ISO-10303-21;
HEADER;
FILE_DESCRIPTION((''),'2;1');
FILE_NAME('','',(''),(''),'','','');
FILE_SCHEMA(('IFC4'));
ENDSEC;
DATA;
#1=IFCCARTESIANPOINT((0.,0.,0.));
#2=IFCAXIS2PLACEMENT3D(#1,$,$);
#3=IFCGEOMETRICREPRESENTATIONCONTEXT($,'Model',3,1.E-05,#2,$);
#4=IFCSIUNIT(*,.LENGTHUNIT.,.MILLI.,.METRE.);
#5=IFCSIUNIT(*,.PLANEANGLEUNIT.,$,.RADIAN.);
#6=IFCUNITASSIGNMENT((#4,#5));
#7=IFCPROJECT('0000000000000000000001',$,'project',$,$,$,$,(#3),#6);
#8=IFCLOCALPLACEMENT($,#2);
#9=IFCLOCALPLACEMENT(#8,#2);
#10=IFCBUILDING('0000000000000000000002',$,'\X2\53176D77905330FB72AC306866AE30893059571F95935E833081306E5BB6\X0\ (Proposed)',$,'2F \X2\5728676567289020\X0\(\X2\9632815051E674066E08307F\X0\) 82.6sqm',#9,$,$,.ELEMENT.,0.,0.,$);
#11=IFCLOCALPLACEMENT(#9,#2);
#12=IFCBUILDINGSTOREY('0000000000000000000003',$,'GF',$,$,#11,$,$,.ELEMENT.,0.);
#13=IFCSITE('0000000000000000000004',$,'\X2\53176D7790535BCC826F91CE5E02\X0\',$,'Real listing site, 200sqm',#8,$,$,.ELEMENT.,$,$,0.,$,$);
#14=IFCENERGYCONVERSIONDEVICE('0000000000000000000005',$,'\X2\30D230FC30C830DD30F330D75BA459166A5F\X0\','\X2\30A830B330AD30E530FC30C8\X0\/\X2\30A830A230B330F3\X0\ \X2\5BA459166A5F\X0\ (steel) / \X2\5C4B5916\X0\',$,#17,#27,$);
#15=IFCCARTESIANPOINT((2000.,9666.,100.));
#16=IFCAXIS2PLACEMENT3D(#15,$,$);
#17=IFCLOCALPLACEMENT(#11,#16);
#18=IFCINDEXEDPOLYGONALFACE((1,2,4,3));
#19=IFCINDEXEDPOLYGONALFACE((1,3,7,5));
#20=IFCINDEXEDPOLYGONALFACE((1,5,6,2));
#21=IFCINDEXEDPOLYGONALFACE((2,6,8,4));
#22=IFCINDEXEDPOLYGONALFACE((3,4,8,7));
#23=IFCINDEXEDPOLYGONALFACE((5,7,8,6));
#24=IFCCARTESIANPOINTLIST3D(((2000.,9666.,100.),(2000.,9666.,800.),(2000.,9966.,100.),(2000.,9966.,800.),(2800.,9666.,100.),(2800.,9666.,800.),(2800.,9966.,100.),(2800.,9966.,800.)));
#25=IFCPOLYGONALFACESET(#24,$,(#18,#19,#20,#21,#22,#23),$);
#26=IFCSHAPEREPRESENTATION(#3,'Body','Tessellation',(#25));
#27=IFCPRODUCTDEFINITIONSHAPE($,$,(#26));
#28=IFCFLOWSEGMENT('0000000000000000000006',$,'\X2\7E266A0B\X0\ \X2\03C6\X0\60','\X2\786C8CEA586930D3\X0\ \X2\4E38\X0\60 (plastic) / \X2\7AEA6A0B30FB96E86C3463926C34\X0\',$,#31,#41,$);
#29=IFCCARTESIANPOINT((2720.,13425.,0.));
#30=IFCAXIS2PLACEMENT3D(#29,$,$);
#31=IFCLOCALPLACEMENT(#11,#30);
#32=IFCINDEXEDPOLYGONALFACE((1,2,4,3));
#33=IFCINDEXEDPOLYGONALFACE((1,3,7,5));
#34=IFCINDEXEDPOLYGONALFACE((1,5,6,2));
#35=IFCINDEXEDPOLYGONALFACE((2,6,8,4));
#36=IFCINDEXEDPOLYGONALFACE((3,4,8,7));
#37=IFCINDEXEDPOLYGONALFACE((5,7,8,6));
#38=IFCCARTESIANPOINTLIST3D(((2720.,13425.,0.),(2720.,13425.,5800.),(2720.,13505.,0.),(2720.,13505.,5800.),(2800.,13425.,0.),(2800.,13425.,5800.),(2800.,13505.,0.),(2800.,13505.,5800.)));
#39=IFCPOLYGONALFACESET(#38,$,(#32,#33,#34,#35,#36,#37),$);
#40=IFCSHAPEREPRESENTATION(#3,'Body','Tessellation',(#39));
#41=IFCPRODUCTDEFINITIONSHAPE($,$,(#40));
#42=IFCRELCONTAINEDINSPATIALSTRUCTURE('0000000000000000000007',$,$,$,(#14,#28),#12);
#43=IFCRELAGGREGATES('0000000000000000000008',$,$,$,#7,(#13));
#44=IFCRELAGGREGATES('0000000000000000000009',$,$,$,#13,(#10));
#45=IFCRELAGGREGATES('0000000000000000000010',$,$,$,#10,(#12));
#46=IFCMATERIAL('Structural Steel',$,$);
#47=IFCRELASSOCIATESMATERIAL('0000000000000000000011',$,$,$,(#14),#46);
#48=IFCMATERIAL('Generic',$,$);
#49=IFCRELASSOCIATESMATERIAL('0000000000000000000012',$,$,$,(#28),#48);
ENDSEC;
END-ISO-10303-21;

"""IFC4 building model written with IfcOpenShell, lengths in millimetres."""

from ifc_helpers import new_model, si_unit, frame, frame_2d, origin, place, context, project, spatial, rectangle, extrude, material, element, save


model = new_model("IFC4")

# Units and contexts
model_context = context("Model", 3, precision=1e-05, world=origin())
ifc_project = project(units=[si_unit("LENGTHUNIT", "METRE", prefix="MILLI"), si_unit("PLANEANGLEUNIT", "RADIAN")], contexts=[model_context])

# Site, building, storey
site_placement = place(None, origin())
site = spatial("IfcSite", under=ifc_project, at=site_placement, Name="北海道富良野市", ObjectType="Real listing site, 200sqm", CompositionType="ELEMENT", RefElevation=0.0)
building_placement = place(site_placement, origin())
building = spatial("IfcBuilding", under=site, at=building_placement, Name="北海道・犬と暮らす土間広めの家 (Proposed)", ObjectType="2F 在来木造(防腐処理済み) 82.6sqm", CompositionType="ELEMENT", ElevationOfRefHeight=0.0, ElevationOfTerrain=0.0)
storey_placement = place(building_placement, origin())
storey = spatial("IfcBuildingStorey", under=building, at=storey_placement, Name="GF", CompositionType="ELEMENT", Elevation=0.0)

# Shared definitions
ifc_material_1 = material(Name="Generic")

# Energy conversion device
ifc_material_2 = material(Name="Structural Steel")
energy_conversion_device_placement = place(storey_placement, frame((2000.0, 9666.0, 100.0)))
element("IfcEnergyConversionDevice", 1, at=energy_conversion_device_placement, inside=storey, material=ifc_material_2, Name="ヒートポンプ室外機", Description="エコキュート/エアコン 室外機 (steel) / 屋外", context=model_context, shape_type="SweptSolid", body=[
    extrude(rectangle(XDim=800.0, YDim=300.0, at=frame_2d((400.0, 150.0))), frame((2000.0, 9666.0, 100.0)), (0.0, 0.0, 1.0), 700.0),
])

# Flow segment
flow_segment_placement = place(storey_placement, frame((2720.0, 13425.0, 0.0)))
element("IfcFlowSegment", 2, at=flow_segment_placement, inside=storey, material=ifc_material_1, Name="縦樋 φ60", Description="硬質塩ビ 丸60 (plastic) / 竪樋・雨水排水", context=model_context, shape_type="SweptSolid", body=[
    extrude(rectangle(XDim=80.0, YDim=80.0, at=frame_2d((40.0, 40.0))), frame((2720.0, 13425.0, 0.0)), (0.0, 0.0, 1.0), 5800.0),
])

save(model, "model.ifc")
